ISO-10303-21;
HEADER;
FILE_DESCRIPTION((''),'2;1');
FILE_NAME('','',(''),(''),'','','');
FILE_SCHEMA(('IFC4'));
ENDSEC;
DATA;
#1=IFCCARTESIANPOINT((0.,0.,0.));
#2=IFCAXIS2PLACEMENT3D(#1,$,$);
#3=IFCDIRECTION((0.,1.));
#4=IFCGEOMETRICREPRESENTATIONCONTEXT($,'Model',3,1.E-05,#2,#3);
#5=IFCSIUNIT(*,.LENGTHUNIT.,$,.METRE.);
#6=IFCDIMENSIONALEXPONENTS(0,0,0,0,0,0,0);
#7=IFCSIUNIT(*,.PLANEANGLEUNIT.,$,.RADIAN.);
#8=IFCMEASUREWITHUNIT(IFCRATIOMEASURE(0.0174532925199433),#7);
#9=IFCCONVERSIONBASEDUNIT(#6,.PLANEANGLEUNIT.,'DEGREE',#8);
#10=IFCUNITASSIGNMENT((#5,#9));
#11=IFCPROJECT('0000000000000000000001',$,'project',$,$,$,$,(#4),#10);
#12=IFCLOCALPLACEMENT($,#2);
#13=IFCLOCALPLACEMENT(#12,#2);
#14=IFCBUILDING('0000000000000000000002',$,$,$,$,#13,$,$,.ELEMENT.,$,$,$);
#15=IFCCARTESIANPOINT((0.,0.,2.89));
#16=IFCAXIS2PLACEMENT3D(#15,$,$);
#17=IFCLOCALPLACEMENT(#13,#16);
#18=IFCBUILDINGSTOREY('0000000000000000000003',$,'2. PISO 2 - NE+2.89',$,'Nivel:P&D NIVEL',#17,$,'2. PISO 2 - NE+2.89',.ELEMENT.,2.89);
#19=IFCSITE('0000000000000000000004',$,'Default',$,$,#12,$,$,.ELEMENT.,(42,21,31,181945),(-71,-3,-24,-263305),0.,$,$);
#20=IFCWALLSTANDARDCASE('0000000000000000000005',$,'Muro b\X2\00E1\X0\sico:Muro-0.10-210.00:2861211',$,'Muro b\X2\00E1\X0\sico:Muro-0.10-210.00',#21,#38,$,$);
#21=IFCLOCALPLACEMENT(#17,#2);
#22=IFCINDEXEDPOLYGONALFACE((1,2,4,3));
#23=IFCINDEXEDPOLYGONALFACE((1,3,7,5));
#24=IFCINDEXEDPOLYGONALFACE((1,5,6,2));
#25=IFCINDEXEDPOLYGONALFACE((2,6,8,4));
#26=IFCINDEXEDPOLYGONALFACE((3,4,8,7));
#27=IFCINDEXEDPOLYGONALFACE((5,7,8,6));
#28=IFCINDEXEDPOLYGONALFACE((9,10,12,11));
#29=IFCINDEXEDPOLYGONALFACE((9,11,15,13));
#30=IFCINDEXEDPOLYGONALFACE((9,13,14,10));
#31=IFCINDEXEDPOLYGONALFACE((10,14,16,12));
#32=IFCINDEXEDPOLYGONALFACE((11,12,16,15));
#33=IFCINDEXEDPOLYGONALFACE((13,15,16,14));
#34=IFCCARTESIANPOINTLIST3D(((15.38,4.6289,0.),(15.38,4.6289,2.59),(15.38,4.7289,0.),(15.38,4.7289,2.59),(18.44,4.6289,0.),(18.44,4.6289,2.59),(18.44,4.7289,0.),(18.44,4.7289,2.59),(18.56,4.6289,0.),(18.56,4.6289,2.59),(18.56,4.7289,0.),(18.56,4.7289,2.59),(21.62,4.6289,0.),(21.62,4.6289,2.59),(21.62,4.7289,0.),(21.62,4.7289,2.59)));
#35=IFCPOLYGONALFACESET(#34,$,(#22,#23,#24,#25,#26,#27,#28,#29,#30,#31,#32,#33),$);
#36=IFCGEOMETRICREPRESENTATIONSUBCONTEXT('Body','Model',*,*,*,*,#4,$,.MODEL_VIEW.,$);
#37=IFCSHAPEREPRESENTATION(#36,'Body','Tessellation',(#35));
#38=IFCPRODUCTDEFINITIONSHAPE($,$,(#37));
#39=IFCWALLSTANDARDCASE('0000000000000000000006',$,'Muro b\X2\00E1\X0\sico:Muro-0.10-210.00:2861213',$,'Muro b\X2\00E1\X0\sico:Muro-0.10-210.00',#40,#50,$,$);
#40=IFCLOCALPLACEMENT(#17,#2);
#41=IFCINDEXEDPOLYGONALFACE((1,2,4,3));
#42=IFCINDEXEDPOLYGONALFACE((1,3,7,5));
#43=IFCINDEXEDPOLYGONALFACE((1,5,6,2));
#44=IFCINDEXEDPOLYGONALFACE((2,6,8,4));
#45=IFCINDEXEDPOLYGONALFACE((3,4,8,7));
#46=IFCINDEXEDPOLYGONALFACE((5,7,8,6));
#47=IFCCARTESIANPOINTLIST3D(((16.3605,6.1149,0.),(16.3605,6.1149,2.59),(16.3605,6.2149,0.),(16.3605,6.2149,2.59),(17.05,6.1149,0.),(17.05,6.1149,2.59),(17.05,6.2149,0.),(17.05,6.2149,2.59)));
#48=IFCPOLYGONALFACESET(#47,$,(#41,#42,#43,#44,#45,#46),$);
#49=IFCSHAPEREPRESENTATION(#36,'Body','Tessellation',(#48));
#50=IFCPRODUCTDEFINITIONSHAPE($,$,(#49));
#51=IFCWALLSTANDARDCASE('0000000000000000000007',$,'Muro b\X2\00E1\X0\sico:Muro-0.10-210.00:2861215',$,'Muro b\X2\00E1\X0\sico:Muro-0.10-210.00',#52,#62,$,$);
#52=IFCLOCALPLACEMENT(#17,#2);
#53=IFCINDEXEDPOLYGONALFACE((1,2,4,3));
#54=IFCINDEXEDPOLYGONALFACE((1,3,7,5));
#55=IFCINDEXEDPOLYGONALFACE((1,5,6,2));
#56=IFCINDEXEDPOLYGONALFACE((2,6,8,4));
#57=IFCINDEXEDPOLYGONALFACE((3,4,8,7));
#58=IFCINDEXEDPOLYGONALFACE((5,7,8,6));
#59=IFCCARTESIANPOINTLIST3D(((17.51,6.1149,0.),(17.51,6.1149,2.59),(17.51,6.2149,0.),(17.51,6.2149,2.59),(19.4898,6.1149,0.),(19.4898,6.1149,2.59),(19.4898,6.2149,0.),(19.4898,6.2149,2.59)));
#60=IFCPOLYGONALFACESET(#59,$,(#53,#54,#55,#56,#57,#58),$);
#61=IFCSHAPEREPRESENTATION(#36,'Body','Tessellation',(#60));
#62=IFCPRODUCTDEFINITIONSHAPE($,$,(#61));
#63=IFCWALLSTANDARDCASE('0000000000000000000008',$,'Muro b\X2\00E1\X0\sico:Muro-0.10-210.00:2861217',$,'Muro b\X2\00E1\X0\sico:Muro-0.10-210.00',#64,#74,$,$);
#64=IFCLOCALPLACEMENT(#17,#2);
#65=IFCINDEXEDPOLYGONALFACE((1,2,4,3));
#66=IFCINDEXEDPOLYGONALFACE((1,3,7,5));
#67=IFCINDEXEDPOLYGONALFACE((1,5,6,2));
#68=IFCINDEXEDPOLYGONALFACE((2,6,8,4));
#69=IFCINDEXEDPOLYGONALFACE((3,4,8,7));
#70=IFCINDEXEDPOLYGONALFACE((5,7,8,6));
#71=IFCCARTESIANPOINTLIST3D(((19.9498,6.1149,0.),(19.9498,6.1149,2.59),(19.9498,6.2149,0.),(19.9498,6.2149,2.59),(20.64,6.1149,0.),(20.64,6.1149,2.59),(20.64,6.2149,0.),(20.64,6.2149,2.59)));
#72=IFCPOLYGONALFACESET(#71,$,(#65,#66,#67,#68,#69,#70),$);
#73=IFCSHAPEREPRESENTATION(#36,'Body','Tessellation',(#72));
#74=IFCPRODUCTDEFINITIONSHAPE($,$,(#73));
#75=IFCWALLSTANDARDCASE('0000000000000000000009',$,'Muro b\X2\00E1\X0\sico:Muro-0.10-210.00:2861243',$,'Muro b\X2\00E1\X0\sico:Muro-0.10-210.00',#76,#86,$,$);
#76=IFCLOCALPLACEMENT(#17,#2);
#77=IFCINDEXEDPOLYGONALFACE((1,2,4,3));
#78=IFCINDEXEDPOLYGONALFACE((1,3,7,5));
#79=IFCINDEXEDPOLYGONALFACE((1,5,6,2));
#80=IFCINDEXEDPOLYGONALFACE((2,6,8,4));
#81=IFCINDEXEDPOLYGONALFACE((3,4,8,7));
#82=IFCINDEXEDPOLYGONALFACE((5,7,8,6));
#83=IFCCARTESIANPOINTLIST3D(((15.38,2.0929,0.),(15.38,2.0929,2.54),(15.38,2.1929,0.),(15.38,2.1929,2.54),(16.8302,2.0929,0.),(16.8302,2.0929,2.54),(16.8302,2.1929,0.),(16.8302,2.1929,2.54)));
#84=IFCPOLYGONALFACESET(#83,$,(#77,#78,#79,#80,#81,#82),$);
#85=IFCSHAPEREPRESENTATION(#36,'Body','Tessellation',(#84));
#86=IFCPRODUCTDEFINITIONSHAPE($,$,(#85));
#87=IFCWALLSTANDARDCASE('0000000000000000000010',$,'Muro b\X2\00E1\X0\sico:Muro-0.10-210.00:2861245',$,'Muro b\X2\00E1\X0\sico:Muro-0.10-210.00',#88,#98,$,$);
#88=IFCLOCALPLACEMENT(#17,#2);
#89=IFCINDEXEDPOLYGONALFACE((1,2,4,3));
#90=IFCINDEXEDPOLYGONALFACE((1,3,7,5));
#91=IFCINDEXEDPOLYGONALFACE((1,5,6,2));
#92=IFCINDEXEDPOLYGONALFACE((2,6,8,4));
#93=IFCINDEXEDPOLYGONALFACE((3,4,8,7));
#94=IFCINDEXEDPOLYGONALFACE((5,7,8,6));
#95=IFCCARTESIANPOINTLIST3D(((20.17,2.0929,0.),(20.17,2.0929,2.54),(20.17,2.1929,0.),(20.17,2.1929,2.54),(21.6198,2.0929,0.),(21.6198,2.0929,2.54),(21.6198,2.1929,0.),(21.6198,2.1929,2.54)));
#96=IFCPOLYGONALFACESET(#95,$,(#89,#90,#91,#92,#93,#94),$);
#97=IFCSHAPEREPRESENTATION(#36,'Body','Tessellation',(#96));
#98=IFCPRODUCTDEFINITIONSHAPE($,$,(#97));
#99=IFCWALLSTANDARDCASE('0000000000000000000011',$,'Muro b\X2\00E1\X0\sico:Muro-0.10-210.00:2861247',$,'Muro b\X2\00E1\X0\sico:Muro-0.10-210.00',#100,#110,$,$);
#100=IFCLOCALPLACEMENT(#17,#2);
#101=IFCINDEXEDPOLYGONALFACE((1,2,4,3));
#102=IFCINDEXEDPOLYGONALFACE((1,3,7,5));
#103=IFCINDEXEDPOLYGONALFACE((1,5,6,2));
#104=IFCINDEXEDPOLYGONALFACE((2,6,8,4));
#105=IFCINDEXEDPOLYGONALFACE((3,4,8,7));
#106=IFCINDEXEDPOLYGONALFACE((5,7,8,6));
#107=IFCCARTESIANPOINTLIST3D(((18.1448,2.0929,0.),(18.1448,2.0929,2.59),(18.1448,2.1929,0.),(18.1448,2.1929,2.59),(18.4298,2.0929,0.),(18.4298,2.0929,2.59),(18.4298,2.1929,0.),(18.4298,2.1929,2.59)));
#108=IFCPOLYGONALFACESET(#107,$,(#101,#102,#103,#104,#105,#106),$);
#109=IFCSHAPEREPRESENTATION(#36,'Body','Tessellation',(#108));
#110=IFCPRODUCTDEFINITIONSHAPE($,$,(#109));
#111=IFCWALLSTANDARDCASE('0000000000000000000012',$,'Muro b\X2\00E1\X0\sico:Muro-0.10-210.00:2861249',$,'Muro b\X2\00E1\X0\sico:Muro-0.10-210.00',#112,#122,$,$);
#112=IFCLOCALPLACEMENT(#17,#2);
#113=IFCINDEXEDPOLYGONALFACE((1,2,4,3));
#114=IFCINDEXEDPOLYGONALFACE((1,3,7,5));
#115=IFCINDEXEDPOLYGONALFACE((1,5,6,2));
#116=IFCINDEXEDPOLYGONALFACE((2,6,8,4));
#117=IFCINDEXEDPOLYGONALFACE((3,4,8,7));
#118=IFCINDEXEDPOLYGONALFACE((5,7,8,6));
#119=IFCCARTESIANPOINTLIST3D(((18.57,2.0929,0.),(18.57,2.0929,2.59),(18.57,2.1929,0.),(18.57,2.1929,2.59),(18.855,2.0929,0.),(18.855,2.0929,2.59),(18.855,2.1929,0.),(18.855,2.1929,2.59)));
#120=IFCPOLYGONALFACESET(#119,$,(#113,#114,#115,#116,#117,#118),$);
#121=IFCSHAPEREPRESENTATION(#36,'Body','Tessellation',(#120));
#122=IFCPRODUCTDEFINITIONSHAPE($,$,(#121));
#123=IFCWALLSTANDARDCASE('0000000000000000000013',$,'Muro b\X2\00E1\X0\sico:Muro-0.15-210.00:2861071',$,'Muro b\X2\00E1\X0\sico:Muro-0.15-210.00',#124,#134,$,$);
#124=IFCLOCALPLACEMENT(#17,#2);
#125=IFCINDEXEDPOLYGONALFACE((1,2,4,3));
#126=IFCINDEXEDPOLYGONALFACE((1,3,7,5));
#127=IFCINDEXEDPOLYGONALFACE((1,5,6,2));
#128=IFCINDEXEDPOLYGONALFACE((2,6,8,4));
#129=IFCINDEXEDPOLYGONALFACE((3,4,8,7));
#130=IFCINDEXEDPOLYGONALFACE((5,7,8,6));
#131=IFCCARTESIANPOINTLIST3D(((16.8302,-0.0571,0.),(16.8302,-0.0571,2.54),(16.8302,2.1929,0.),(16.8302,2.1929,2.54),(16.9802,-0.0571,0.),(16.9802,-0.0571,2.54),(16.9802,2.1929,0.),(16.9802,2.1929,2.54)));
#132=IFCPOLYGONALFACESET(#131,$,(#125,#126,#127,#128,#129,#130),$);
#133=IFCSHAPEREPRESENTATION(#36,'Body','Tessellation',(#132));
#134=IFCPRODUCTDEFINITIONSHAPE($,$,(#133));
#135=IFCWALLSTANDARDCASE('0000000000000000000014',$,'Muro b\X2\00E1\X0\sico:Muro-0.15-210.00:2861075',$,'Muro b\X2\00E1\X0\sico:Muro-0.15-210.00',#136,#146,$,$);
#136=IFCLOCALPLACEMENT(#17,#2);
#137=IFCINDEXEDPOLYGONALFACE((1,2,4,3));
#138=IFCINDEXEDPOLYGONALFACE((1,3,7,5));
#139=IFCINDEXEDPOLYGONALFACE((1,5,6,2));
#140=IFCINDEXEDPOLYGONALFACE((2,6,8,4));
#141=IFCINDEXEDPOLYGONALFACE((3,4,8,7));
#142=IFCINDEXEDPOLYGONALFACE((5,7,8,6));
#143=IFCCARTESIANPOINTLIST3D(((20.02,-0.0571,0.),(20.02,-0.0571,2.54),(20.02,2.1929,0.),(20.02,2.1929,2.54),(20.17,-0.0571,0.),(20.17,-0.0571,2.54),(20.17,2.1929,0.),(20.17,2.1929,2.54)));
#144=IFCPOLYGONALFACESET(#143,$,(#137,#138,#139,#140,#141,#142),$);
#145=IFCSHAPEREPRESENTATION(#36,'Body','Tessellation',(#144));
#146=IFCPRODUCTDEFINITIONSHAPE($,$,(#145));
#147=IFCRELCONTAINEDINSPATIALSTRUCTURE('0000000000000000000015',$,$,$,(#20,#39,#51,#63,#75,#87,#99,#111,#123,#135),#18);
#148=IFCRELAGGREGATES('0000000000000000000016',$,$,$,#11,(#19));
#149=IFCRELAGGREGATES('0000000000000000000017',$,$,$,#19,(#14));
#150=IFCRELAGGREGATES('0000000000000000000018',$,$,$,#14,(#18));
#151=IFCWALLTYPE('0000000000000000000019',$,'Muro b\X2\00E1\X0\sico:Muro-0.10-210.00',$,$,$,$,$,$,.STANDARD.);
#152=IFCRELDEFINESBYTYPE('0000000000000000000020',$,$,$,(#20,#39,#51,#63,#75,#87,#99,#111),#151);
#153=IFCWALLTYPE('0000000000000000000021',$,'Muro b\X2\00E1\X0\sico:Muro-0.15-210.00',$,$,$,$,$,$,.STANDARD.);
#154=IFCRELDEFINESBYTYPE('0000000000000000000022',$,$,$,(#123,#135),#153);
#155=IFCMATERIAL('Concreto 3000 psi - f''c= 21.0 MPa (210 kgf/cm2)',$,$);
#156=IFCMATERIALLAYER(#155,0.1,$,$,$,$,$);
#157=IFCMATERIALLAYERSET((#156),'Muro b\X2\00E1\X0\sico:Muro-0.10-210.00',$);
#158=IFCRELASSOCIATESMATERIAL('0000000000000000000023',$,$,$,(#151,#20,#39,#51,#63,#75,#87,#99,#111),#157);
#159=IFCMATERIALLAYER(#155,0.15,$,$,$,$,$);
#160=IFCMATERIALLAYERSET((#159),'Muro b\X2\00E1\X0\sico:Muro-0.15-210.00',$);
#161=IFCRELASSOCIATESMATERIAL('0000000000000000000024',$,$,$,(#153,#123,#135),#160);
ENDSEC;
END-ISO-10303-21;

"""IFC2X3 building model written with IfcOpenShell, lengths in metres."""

from ifc_helpers import new_model, entity, si_unit, converted_unit, direction, frame, frame_2d, origin, origin_2d_with_axis, place, context, subcontext, project, spatial, rectangle, extrude, material, layer, layer_set, layer_usage, type_object, element, save


model = new_model("IFC2X3")

# Units and contexts
model_context = context("Model", 3, precision=1e-05, world=origin(), true_north=direction((0.0, 1.0)))
body_context = subcontext(model_context, "Body", "Model", "MODEL_VIEW")
ifc_project = project(units=[si_unit("LENGTHUNIT", "METRE"), converted_unit("PLANEANGLEUNIT", "DEGREE", entity("IfcRatioMeasure", 0.0174532925199433), si_unit("PLANEANGLEUNIT", "RADIAN"), dimensions=[0, 0, 0, 0, 0, 0, 0])], contexts=[model_context])

# Site, building, storey
site_placement = place(None, origin())
site = spatial("IfcSite", under=ifc_project, at=site_placement, Name="Default", CompositionType="ELEMENT", RefLatitude=(42, 21, 31, 181945), RefLongitude=(-71, -3, -24, -263305), RefElevation=0.0)
building_placement = place(site_placement, origin())
building = spatial("IfcBuilding", under=site, at=building_placement, CompositionType="ELEMENT")
storey_placement = place(building_placement, frame((0.0, 0.0, 2.89)))
storey = spatial("IfcBuildingStorey", under=building, at=storey_placement, Name="2. PISO 2 - NE+2.89", ObjectType="Nivel:P&D NIVEL", LongName="2. PISO 2 - NE+2.89", CompositionType="ELEMENT", Elevation=2.89)

# Shared definitions
ifc_material = material(Name="Concreto 3000 psi - f'c= 21.0 MPa (210 kgf/cm2)")

# Shared definitions
ifc_layer_1 = layer(ifc_material, 0.1)
ifc_layer_set_1 = layer_set([ifc_layer_1], Name="Muro básico:Muro-0.10-210.00")
ifc_layer_usage_1 = layer_usage(ifc_layer_set_1, "AXIS2", "POSITIVE", -0.05)
wall_type_1 = type_object("IfcWallType", Name="Muro básico:Muro-0.10-210.00", PredefinedType="STANDARD", material=ifc_layer_set_1)

# Wall, opening
ifc_layer_usage_2 = layer_usage(ifc_layer_set_1, "AXIS2", "NEGATIVE", 0.05)
wall_1_placement = place(storey_placement, frame((15.38, 4.6789, 0.0)))
wall_1 = element("IfcWallStandardCase", 1, at=wall_1_placement, inside=storey, type_object=wall_type_1, material=ifc_layer_usage_2, Name="Muro básico:Muro-0.10-210.00:2861211", ObjectType="Muro básico:Muro-0.10-210.00", context=body_context, shape_type="SweptSolid", body=[
    extrude(rectangle(XDim=6.24, YDim=0.1, at=frame_2d((3.12, 0.0), x_axis=(-1.0, 0.0))), origin(), (0.0, 0.0, 1.0), 2.59),
])
opening_placement = place(storey_placement, frame((15.38, 4.6789, 0.0)))
element("IfcOpeningElement", 2, at=opening_placement, cuts=wall_1, ObjectType="Opening", context=body_context, shape_type="SweptSolid", body=[
    extrude(rectangle(XDim=2.59, YDim=0.1, at=origin_2d_with_axis()), frame((3.06, 0.0, 1.295), z_axis=(1.0, 0.0, 0.0), x_axis=(0.0, 0.0, -1.0)), (0.0, 0.0, 1.0), 0.12),
])

# Walls
wall_2_placement = place(storey_placement, frame((16.3605, 6.1649, 0.0)))
element("IfcWallStandardCase", 3, at=wall_2_placement, inside=storey, type_object=wall_type_1, material=ifc_layer_usage_1, Name="Muro básico:Muro-0.10-210.00:2861213", ObjectType="Muro básico:Muro-0.10-210.00", context=body_context, shape_type="SweptSolid", body=[
    extrude(rectangle(XDim=0.6895, YDim=0.1, at=frame_2d((0.3447, 0.0), x_axis=(-1.0, 0.0))), origin(), (0.0, 0.0, 1.0), 2.59),
])
wall_3_placement = place(storey_placement, frame((17.51, 6.1649, 0.0)))
element("IfcWallStandardCase", 4, at=wall_3_placement, inside=storey, type_object=wall_type_1, material=ifc_layer_usage_1, Name="Muro básico:Muro-0.10-210.00:2861215", ObjectType="Muro básico:Muro-0.10-210.00", context=body_context, shape_type="SweptSolid", body=[
    extrude(rectangle(XDim=1.9798, YDim=0.1, at=frame_2d((0.9899, 0.0), x_axis=(-1.0, 0.0))), origin(), (0.0, 0.0, 1.0), 2.59),
])
wall_4_placement = place(storey_placement, frame((19.9498, 6.1649, 0.0)))
element("IfcWallStandardCase", 5, at=wall_4_placement, inside=storey, type_object=wall_type_1, material=ifc_layer_usage_1, Name="Muro básico:Muro-0.10-210.00:2861217", ObjectType="Muro básico:Muro-0.10-210.00", context=body_context, shape_type="SweptSolid", body=[
    extrude(rectangle(XDim=0.6902, YDim=0.1, at=frame_2d((0.3451, 0.0), x_axis=(-1.0, 0.0))), origin(), (0.0, 0.0, 1.0), 2.59),
])
wall_5_placement = place(storey_placement, frame((15.38, 2.1429, 0.0)))
element("IfcWallStandardCase", 6, at=wall_5_placement, inside=storey, type_object=wall_type_1, material=ifc_layer_usage_1, Name="Muro básico:Muro-0.10-210.00:2861243", ObjectType="Muro básico:Muro-0.10-210.00", context=body_context, shape_type="SweptSolid", body=[
    extrude(rectangle(XDim=1.4502, YDim=0.1, at=frame_2d((0.7251, 0.0), x_axis=(-1.0, 0.0))), origin(), (0.0, 0.0, 1.0), 2.54),
])
wall_6_placement = place(storey_placement, frame((20.17, 2.1429, 0.0)))
element("IfcWallStandardCase", 7, at=wall_6_placement, inside=storey, type_object=wall_type_1, material=ifc_layer_usage_1, Name="Muro básico:Muro-0.10-210.00:2861245", ObjectType="Muro básico:Muro-0.10-210.00", context=body_context, shape_type="SweptSolid", body=[
    extrude(rectangle(XDim=1.4498, YDim=0.1, at=frame_2d((0.7249, 0.0), x_axis=(-1.0, 0.0))), origin(), (0.0, 0.0, 1.0), 2.54),
])
wall_7_placement = place(storey_placement, frame((18.1448, 2.1429, 0.0)))
element("IfcWallStandardCase", 8, at=wall_7_placement, inside=storey, type_object=wall_type_1, material=ifc_layer_usage_1, Name="Muro básico:Muro-0.10-210.00:2861247", ObjectType="Muro básico:Muro-0.10-210.00", context=body_context, shape_type="SweptSolid", body=[
    extrude(rectangle(XDim=0.285, YDim=0.1, at=frame_2d((0.1425, 0.0), x_axis=(-1.0, 0.0))), origin(), (0.0, 0.0, 1.0), 2.59),
])
wall_8_placement = place(storey_placement, frame((18.57, 2.1429, 0.0)))
element("IfcWallStandardCase", 9, at=wall_8_placement, inside=storey, type_object=wall_type_1, material=ifc_layer_usage_1, Name="Muro básico:Muro-0.10-210.00:2861249", ObjectType="Muro básico:Muro-0.10-210.00", context=body_context, shape_type="SweptSolid", body=[
    extrude(rectangle(XDim=0.285, YDim=0.1, at=frame_2d((0.1425, 0.0), x_axis=(-1.0, 0.0))), origin(), (0.0, 0.0, 1.0), 2.59),
])
ifc_layer_2 = layer(ifc_material, 0.15)
ifc_layer_set_2 = layer_set([ifc_layer_2], Name="Muro básico:Muro-0.15-210.00")
ifc_layer_usage_3 = layer_usage(ifc_layer_set_2, "AXIS2", "POSITIVE", -0.075)
wall_type_2 = type_object("IfcWallType", Name="Muro básico:Muro-0.15-210.00", PredefinedType="STANDARD", material=ifc_layer_set_2)
wall_9_placement = place(storey_placement, frame((16.9052, -0.0571, 0.0), z_axis=(0.0, 0.0, 1.0), x_axis=(0.0, 1.0, 0.0)))
element("IfcWallStandardCase", 10, at=wall_9_placement, inside=storey, type_object=wall_type_2, material=ifc_layer_usage_3, Name="Muro básico:Muro-0.15-210.00:2861071", ObjectType="Muro básico:Muro-0.15-210.00", context=body_context, shape_type="SweptSolid", body=[
    extrude(rectangle(XDim=2.25, YDim=0.15, at=frame_2d((1.125, 0.0), x_axis=(-1.0, 0.0))), origin(), (0.0, 0.0, 1.0), 2.54),
])
wall_10_placement = place(storey_placement, frame((20.095, -0.0571, 0.0), z_axis=(0.0, 0.0, 1.0), x_axis=(0.0, 1.0, 0.0)))
element("IfcWallStandardCase", 11, at=wall_10_placement, inside=storey, type_object=wall_type_2, material=ifc_layer_usage_3, Name="Muro básico:Muro-0.15-210.00:2861075", ObjectType="Muro básico:Muro-0.15-210.00", context=body_context, shape_type="SweptSolid", body=[
    extrude(rectangle(XDim=2.25, YDim=0.15, at=frame_2d((1.125, 0.0), x_axis=(-1.0, 0.0))), origin(), (0.0, 0.0, 1.0), 2.54),
])

save(model, "model.ifc")
